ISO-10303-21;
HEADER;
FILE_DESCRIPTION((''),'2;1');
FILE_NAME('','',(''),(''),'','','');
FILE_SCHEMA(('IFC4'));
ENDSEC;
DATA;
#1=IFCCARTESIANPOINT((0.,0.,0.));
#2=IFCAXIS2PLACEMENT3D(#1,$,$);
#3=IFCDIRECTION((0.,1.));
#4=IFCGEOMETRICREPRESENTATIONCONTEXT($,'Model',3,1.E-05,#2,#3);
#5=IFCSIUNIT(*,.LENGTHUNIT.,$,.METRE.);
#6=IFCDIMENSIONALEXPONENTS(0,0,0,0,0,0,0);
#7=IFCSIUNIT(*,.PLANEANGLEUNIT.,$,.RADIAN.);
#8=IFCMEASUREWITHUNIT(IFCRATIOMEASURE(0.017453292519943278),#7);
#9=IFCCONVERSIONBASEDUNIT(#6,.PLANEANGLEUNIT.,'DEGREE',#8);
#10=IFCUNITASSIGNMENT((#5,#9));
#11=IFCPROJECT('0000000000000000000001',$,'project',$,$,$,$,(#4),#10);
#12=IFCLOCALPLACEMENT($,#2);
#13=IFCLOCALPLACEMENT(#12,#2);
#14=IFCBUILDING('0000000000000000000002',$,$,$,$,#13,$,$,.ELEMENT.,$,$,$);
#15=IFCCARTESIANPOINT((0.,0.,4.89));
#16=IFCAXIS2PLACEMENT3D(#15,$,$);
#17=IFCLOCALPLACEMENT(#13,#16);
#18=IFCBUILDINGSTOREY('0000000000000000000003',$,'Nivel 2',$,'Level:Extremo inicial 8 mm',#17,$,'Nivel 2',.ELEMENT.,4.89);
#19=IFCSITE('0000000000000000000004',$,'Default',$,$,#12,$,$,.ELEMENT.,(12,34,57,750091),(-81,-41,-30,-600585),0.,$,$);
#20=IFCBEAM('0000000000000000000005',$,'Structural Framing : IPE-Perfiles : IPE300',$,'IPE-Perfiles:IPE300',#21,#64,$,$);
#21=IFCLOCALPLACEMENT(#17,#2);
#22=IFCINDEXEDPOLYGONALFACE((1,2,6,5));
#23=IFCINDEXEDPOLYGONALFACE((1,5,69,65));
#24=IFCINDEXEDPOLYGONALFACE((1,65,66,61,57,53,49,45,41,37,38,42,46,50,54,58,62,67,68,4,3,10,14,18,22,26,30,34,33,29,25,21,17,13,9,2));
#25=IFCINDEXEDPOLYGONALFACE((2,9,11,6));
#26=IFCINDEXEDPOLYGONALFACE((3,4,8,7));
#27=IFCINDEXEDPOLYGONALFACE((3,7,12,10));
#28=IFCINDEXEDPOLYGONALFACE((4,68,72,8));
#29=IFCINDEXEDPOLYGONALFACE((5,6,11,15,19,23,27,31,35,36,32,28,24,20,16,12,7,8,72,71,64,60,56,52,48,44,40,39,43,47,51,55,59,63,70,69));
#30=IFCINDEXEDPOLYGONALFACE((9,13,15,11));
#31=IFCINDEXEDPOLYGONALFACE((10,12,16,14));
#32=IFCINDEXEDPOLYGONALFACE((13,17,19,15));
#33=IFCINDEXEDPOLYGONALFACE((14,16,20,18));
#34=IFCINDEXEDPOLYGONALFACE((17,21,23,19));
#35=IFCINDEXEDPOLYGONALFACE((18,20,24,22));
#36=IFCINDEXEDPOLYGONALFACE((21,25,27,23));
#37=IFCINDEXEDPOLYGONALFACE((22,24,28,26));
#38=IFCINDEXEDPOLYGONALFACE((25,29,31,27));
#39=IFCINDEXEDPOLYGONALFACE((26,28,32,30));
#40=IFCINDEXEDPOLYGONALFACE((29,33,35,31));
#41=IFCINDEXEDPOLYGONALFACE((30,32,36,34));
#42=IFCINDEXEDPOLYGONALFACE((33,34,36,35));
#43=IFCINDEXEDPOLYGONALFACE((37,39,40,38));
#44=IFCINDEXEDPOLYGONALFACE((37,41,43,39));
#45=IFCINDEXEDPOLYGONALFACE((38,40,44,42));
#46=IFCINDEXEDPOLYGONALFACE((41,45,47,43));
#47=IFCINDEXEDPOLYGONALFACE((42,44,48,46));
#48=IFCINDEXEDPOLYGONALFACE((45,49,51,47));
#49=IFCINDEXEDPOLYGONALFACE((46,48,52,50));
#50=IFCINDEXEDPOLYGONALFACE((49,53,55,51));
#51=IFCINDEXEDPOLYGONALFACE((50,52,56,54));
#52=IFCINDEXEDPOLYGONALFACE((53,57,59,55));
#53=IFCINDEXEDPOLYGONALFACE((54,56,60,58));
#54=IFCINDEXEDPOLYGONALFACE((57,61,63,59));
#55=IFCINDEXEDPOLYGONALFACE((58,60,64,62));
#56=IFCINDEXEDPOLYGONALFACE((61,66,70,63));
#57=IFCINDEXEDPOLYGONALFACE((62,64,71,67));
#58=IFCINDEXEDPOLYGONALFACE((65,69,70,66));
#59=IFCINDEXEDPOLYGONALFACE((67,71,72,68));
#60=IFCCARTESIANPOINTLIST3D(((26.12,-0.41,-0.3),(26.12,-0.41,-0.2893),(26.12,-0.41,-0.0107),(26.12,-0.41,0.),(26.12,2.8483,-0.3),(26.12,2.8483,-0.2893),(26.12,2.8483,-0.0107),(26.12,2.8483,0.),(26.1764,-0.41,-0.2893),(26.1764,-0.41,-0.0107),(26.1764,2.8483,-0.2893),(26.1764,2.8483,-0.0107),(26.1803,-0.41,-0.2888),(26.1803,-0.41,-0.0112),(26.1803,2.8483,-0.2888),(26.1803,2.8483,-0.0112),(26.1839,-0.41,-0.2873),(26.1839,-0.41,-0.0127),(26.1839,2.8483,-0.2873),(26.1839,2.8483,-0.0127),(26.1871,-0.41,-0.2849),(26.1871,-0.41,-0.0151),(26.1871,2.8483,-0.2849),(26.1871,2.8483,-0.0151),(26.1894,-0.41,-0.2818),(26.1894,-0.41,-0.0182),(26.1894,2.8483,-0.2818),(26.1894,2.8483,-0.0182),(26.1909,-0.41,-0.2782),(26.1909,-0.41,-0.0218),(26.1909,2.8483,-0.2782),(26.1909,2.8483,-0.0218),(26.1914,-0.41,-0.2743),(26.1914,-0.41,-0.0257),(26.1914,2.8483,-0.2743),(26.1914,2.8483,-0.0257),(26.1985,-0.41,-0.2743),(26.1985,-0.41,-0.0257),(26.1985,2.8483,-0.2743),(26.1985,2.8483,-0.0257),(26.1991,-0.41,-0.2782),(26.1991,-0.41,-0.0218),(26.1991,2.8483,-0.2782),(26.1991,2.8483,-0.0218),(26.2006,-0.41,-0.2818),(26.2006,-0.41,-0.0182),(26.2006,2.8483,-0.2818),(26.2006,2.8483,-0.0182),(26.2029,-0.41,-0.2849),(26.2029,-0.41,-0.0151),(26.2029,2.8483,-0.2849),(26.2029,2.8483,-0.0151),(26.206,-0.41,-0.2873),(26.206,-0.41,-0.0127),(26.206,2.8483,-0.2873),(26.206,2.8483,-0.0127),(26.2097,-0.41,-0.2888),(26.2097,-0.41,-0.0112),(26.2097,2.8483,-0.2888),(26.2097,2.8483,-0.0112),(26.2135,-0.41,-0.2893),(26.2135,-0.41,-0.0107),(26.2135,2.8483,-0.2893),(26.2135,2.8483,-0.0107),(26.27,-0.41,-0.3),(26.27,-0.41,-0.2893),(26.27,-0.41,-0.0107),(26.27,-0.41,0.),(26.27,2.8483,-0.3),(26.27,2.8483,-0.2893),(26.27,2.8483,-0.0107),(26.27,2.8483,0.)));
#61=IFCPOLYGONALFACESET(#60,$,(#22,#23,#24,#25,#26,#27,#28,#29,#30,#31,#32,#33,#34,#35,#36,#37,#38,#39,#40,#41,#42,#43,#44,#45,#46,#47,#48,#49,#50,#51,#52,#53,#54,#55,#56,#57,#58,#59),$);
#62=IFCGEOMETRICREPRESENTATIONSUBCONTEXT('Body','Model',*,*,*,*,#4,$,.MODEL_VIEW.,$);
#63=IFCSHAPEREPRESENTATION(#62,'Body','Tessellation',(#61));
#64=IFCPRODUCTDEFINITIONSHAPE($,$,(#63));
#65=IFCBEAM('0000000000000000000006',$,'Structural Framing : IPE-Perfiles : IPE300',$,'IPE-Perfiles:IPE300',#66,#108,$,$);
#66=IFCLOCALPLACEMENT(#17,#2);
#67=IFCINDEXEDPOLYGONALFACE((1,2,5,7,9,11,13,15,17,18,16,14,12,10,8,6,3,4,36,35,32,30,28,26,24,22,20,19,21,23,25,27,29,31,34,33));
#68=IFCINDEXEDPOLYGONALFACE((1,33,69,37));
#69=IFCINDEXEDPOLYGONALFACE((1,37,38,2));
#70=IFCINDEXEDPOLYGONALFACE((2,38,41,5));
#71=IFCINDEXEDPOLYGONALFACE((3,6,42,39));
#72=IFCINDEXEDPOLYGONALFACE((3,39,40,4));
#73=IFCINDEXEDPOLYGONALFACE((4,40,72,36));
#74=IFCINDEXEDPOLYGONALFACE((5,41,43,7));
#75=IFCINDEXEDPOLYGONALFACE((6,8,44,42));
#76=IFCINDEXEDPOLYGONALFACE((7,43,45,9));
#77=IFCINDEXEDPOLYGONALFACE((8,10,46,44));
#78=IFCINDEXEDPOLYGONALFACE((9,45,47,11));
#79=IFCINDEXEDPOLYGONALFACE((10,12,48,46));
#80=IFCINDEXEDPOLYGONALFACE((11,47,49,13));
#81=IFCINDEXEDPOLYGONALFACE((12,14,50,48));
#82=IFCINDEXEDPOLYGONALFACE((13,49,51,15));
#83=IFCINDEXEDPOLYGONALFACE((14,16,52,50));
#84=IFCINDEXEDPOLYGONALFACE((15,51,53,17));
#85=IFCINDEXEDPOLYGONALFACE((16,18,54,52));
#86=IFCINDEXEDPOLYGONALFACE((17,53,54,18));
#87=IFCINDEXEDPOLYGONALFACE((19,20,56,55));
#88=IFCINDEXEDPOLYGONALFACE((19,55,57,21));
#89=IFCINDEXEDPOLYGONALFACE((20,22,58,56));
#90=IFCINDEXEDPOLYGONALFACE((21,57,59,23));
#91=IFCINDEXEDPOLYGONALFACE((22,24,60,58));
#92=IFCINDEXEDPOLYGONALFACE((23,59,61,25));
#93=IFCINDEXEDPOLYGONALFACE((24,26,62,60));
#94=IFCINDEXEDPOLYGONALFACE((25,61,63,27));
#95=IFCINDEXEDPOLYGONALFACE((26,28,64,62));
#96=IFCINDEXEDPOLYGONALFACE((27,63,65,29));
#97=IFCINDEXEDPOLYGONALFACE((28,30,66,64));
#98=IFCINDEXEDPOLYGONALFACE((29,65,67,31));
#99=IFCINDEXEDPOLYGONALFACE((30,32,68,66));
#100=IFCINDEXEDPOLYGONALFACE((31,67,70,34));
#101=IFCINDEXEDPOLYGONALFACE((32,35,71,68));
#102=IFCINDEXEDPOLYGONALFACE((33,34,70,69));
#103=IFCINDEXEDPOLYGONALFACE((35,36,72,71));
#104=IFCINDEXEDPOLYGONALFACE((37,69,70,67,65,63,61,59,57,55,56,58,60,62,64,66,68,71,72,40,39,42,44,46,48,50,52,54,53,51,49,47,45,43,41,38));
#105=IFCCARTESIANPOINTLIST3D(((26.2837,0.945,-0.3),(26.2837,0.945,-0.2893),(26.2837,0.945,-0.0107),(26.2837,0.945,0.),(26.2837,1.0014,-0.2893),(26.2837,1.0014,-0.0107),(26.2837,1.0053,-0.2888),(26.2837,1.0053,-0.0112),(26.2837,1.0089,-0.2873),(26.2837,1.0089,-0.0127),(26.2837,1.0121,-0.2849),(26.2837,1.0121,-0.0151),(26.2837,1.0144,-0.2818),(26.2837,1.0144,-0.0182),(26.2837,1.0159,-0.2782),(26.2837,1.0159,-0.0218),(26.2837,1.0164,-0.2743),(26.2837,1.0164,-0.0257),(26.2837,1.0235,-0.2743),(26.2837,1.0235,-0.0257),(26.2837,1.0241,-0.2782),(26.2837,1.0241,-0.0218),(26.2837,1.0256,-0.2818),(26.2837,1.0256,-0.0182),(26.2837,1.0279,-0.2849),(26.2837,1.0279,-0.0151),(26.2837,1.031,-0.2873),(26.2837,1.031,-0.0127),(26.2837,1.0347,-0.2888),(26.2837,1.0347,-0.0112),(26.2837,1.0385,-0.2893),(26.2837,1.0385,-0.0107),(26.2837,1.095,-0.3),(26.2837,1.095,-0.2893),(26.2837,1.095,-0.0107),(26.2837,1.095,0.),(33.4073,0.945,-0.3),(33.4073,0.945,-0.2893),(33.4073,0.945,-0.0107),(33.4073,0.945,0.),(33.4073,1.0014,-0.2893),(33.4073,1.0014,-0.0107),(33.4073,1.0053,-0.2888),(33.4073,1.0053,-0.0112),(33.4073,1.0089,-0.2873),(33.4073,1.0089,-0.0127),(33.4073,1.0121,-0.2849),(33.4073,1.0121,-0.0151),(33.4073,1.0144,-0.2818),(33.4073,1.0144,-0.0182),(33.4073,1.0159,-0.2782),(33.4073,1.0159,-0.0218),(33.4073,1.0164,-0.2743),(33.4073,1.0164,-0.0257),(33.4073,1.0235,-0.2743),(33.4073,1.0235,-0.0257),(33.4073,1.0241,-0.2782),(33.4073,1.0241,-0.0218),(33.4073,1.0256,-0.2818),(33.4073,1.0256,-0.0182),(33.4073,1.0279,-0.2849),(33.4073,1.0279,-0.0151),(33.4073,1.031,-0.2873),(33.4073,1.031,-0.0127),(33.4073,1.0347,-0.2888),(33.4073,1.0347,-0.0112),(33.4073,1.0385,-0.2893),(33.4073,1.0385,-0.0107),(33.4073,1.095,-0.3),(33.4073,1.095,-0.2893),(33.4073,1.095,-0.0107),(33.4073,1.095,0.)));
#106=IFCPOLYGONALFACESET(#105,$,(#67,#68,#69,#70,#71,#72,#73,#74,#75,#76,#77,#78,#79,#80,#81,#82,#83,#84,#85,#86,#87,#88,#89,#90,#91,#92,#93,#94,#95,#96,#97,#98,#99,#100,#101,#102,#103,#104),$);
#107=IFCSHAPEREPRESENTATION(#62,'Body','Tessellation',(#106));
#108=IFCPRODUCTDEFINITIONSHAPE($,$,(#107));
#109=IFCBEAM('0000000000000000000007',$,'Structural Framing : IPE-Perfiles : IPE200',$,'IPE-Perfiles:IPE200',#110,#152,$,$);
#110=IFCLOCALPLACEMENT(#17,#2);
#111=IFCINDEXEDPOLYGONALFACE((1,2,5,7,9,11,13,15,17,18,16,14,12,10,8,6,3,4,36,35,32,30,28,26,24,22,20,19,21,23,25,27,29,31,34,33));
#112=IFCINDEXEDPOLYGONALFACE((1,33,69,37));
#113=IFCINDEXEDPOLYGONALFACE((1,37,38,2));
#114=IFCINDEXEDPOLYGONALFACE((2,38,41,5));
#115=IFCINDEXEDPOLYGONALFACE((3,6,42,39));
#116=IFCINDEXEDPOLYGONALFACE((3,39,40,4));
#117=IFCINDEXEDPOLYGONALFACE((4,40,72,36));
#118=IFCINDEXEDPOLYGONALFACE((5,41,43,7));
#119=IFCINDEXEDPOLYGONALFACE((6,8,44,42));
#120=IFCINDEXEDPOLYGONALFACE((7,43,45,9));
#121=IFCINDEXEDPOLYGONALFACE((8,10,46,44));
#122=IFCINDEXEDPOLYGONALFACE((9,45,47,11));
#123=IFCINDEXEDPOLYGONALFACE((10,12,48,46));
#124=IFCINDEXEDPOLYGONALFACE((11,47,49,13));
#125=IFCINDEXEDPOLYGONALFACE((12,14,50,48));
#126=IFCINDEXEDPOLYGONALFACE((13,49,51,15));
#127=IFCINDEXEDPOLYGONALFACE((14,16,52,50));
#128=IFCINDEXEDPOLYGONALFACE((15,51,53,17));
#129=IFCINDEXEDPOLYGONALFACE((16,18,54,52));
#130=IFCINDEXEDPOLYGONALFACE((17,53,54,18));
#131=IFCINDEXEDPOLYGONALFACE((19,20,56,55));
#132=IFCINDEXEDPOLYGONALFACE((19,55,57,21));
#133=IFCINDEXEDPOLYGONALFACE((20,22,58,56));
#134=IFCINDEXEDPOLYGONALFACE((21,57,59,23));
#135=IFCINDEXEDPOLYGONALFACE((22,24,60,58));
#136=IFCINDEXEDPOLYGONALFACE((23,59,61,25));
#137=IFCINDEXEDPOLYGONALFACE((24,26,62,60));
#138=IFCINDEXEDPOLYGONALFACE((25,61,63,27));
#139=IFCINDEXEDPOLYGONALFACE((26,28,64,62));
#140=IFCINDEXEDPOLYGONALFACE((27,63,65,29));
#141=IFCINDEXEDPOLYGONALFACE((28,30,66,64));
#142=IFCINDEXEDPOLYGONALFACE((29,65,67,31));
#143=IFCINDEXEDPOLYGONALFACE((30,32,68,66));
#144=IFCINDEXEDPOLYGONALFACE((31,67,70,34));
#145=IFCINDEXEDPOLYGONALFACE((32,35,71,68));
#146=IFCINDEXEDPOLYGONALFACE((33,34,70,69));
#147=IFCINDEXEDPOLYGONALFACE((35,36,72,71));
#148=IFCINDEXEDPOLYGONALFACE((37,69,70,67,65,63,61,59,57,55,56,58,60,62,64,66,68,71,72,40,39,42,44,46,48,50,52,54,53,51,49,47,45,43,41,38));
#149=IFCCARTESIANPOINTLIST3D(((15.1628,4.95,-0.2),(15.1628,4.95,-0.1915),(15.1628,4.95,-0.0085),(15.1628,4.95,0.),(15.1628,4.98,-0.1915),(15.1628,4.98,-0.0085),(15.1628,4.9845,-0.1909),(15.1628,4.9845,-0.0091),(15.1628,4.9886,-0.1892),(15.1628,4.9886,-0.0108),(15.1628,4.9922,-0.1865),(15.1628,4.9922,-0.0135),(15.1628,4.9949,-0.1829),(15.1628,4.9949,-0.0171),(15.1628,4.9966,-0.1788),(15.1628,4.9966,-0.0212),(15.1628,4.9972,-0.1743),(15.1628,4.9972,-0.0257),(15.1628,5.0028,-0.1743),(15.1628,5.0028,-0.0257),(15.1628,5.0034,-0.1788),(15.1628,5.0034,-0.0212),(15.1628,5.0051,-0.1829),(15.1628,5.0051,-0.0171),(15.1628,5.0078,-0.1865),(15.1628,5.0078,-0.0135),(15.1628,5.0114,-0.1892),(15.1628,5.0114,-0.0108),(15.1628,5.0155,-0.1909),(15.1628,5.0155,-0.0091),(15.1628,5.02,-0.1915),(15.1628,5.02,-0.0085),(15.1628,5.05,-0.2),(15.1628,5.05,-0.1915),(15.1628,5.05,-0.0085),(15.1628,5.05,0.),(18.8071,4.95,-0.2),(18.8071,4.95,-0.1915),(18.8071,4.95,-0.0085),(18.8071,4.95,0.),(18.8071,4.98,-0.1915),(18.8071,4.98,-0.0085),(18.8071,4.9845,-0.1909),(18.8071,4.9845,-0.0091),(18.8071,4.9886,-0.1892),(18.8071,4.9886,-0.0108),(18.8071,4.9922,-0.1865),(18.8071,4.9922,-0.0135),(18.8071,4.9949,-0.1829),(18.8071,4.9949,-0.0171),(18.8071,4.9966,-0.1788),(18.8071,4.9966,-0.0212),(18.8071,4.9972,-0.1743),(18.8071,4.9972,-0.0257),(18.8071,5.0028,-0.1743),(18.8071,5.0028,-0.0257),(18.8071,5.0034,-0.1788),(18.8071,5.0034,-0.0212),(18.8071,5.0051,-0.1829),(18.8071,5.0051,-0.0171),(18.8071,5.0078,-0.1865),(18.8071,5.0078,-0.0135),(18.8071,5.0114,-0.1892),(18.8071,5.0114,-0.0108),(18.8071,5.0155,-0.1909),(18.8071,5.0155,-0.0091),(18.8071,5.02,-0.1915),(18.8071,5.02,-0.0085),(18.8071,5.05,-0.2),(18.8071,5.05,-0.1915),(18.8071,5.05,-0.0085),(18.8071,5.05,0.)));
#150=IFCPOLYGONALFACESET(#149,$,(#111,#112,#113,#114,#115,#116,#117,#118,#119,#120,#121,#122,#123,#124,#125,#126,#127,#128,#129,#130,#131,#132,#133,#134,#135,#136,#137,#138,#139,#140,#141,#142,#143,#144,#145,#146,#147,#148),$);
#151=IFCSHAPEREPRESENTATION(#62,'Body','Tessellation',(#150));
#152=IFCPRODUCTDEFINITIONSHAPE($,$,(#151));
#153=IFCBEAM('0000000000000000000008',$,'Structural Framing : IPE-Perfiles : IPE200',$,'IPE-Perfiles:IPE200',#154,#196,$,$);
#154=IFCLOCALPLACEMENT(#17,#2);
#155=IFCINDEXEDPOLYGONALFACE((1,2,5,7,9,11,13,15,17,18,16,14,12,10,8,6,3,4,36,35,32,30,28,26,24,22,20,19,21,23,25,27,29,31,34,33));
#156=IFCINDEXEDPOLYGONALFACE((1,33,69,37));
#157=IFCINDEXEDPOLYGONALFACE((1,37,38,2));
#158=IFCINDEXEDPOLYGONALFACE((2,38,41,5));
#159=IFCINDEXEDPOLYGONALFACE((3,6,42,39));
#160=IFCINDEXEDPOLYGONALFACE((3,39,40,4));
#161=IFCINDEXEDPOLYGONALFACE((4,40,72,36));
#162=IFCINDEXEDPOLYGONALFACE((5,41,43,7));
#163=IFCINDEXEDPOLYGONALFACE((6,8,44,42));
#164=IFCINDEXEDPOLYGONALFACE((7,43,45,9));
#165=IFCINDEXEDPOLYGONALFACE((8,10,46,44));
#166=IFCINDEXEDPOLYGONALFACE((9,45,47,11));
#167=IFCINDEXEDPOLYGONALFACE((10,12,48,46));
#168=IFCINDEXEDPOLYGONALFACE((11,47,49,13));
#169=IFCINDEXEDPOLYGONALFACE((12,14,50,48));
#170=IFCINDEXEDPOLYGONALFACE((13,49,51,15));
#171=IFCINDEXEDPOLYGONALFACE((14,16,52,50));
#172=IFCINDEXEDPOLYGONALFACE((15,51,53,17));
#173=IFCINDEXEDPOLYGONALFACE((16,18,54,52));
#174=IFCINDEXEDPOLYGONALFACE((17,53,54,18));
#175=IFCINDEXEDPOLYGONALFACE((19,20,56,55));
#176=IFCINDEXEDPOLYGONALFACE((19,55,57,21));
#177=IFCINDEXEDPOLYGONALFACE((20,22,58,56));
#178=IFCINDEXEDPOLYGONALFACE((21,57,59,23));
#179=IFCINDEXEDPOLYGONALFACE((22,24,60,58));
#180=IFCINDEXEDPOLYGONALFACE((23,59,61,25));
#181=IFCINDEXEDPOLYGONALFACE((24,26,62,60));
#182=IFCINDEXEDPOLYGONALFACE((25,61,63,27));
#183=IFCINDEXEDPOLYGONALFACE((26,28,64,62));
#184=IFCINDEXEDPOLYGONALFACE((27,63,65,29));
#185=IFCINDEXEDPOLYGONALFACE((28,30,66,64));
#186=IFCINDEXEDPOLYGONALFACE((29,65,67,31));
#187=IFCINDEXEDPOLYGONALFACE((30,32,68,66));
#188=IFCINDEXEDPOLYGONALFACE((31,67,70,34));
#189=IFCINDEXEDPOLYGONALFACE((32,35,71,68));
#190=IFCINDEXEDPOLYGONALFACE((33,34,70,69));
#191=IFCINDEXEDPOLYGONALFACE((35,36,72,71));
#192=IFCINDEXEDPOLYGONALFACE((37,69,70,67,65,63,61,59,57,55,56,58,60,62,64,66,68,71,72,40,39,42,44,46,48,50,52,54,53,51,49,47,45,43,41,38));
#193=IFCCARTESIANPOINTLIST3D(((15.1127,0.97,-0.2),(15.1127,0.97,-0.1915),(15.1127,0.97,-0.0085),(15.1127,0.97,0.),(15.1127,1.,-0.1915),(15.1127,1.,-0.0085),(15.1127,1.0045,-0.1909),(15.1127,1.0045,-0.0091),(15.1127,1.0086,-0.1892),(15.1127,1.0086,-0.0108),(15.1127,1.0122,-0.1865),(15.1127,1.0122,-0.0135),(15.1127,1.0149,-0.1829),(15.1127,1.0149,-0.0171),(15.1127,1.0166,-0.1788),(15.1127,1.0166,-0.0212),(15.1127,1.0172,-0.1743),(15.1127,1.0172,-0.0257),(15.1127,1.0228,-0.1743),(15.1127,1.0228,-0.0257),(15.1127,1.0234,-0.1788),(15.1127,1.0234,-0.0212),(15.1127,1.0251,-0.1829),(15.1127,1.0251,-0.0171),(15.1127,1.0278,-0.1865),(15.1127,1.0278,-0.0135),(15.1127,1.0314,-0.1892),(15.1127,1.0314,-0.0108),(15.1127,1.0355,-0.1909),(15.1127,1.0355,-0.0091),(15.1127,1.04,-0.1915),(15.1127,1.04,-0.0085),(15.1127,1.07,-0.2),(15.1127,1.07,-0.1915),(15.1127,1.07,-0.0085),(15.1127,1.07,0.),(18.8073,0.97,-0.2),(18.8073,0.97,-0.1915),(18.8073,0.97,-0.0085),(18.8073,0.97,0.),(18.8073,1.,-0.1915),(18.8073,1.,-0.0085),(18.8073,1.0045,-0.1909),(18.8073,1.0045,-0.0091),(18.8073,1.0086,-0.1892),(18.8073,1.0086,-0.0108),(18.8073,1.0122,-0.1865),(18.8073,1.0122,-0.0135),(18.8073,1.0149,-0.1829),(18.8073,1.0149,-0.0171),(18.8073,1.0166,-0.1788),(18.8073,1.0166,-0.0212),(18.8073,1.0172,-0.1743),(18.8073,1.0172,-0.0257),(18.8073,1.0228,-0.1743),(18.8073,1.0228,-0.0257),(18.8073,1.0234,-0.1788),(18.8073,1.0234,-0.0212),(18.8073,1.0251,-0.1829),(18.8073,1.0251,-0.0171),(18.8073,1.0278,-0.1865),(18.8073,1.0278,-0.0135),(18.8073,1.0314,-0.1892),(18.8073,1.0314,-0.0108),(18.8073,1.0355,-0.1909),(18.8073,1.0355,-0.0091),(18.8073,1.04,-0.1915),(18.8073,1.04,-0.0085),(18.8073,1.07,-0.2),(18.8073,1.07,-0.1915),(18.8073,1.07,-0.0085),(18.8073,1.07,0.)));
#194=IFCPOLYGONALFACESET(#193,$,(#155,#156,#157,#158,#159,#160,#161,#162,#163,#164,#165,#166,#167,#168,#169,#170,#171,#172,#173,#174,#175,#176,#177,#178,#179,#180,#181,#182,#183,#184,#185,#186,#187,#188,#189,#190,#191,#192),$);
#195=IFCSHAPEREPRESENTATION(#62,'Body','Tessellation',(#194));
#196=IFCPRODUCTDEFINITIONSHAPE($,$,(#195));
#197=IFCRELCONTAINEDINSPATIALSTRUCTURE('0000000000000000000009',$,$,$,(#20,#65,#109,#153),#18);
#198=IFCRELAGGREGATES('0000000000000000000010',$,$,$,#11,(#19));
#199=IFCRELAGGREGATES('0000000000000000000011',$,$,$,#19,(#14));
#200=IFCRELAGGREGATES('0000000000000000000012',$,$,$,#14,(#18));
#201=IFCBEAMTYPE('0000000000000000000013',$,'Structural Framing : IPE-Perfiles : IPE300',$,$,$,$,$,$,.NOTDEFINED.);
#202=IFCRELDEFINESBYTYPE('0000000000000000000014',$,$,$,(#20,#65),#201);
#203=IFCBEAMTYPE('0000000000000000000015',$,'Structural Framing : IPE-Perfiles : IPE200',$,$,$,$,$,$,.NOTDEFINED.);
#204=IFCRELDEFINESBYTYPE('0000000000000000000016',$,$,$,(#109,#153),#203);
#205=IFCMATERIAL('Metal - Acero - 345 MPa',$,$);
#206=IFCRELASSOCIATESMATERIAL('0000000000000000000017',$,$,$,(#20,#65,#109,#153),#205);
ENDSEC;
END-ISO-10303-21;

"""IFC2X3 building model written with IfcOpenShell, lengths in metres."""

from ifc_helpers import new_model, entity, si_unit, converted_unit, direction, frame, frame_2d, origin, place, context, subcontext, project, spatial, i_section, extrude, material, type_object, element, save


model = new_model("IFC2X3")

# Units and contexts
model_context = context("Model", 3, precision=1e-05, world=origin(), true_north=direction((0.0, 1.0)))
body_context = subcontext(model_context, "Body", "Model", "MODEL_VIEW")
ifc_project = project(units=[si_unit("LENGTHUNIT", "METRE"), converted_unit("PLANEANGLEUNIT", "DEGREE", entity("IfcRatioMeasure", 0.017453292519943278), si_unit("PLANEANGLEUNIT", "RADIAN"), dimensions=[0, 0, 0, 0, 0, 0, 0])], contexts=[model_context])

# Site, building, storey
site_placement = place(None, origin())
site = spatial("IfcSite", under=ifc_project, at=site_placement, Name="Default", CompositionType="ELEMENT", RefLatitude=(12, 34, 57, 750091), RefLongitude=(-81, -41, -30, -600585), RefElevation=0.0)
building_placement = place(site_placement, origin())
building = spatial("IfcBuilding", under=site, at=building_placement, CompositionType="ELEMENT")
storey_placement = place(building_placement, frame((0.0, 0.0, 4.89)))
storey = spatial("IfcBuildingStorey", under=building, at=storey_placement, Name="Nivel 2", ObjectType="Level:Extremo inicial 8 mm", LongName="Nivel 2", CompositionType="ELEMENT", Elevation=4.89)

# Shared definitions
ifc_material_1 = material(Name="Metal - Acero - 345 MPa")

# Beams
beam_type_1 = type_object("IfcBeamType", Name="Structural Framing : IPE-Perfiles : IPE300", PredefinedType="NOTDEFINED")
beam_1_placement = place(storey_placement, frame((26.195, -0.35, 0.0), z_axis=(0.0, 0.0, 1.0), x_axis=(0.0, 1.0, 0.0)))
element("IfcBeam", 1, at=beam_1_placement, inside=storey, type_object=beam_type_1, material=ifc_material_1, Name="Structural Framing : IPE-Perfiles : IPE300", ObjectType="IPE-Perfiles:IPE300", context=body_context, shape_type="SweptSolid", body=[
    extrude(i_section(OverallWidth=0.15, OverallDepth=0.3, WebThickness=0.0071, FlangeThickness=0.0107, FilletRadius=0.015, at=frame_2d((0.0, 0.0), x_axis=(0.0, 1.0))), frame((-0.06, 0.0, -0.15), z_axis=(1.0, 0.0, 0.0), x_axis=(0.0, 0.0, -1.0)), (0.0, 0.0, 1.0), 3.2583),
])
beam_2_placement = place(storey_placement, frame((26.195, 1.02, 0.0)))
element("IfcBeam", 2, at=beam_2_placement, inside=storey, type_object=beam_type_1, material=ifc_material_1, Name="Structural Framing : IPE-Perfiles : IPE300", ObjectType="IPE-Perfiles:IPE300", context=body_context, shape_type="SweptSolid", body=[
    extrude(i_section(OverallWidth=0.15, OverallDepth=0.3, WebThickness=0.0071, FlangeThickness=0.0107, FilletRadius=0.015, at=frame_2d((0.0, 0.0), x_axis=(0.0, 1.0))), frame((0.0887, 0.0, -0.15), z_axis=(1.0, 0.0, 0.0), x_axis=(0.0, 0.0, -1.0)), (0.0, 0.0, 1.0), 7.1236),
])
beam_type_2 = type_object("IfcBeamType", Name="Structural Framing : IPE-Perfiles : IPE200", PredefinedType="NOTDEFINED")
beam_3_placement = place(storey_placement, frame((15.1625, 5.0, 0.0)))
element("IfcBeam", 3, at=beam_3_placement, inside=storey, type_object=beam_type_2, material=ifc_material_1, Name="Structural Framing : IPE-Perfiles : IPE200", ObjectType="IPE-Perfiles:IPE200", context=body_context, shape_type="SweptSolid", body=[
    extrude(i_section(OverallWidth=0.1, OverallDepth=0.2, WebThickness=0.0056, FlangeThickness=0.0085, FilletRadius=0.0172, at=frame_2d((0.0, 0.0), x_axis=(0.0, 1.0))), frame((0.0002, 0.0, -0.1), z_axis=(1.0, 0.0, 0.0), x_axis=(0.0, 0.0, -1.0)), (0.0, 0.0, 1.0), 3.6443),
])
beam_4_placement = place(storey_placement, frame((15.05, 1.02, 0.0)))
element("IfcBeam", 4, at=beam_4_placement, inside=storey, type_object=beam_type_2, material=ifc_material_1, Name="Structural Framing : IPE-Perfiles : IPE200", ObjectType="IPE-Perfiles:IPE200", context=body_context, shape_type="SweptSolid", body=[
    extrude(i_section(OverallWidth=0.1, OverallDepth=0.2, WebThickness=0.0056, FlangeThickness=0.0085, FilletRadius=0.0172, at=frame_2d((0.0, 0.0), x_axis=(0.0, 1.0))), frame((0.0627, 0.0, -0.1), z_axis=(1.0, 0.0, 0.0), x_axis=(0.0, 0.0, -1.0)), (0.0, 0.0, 1.0), 3.6946),
])

save(model, "model.ifc")
